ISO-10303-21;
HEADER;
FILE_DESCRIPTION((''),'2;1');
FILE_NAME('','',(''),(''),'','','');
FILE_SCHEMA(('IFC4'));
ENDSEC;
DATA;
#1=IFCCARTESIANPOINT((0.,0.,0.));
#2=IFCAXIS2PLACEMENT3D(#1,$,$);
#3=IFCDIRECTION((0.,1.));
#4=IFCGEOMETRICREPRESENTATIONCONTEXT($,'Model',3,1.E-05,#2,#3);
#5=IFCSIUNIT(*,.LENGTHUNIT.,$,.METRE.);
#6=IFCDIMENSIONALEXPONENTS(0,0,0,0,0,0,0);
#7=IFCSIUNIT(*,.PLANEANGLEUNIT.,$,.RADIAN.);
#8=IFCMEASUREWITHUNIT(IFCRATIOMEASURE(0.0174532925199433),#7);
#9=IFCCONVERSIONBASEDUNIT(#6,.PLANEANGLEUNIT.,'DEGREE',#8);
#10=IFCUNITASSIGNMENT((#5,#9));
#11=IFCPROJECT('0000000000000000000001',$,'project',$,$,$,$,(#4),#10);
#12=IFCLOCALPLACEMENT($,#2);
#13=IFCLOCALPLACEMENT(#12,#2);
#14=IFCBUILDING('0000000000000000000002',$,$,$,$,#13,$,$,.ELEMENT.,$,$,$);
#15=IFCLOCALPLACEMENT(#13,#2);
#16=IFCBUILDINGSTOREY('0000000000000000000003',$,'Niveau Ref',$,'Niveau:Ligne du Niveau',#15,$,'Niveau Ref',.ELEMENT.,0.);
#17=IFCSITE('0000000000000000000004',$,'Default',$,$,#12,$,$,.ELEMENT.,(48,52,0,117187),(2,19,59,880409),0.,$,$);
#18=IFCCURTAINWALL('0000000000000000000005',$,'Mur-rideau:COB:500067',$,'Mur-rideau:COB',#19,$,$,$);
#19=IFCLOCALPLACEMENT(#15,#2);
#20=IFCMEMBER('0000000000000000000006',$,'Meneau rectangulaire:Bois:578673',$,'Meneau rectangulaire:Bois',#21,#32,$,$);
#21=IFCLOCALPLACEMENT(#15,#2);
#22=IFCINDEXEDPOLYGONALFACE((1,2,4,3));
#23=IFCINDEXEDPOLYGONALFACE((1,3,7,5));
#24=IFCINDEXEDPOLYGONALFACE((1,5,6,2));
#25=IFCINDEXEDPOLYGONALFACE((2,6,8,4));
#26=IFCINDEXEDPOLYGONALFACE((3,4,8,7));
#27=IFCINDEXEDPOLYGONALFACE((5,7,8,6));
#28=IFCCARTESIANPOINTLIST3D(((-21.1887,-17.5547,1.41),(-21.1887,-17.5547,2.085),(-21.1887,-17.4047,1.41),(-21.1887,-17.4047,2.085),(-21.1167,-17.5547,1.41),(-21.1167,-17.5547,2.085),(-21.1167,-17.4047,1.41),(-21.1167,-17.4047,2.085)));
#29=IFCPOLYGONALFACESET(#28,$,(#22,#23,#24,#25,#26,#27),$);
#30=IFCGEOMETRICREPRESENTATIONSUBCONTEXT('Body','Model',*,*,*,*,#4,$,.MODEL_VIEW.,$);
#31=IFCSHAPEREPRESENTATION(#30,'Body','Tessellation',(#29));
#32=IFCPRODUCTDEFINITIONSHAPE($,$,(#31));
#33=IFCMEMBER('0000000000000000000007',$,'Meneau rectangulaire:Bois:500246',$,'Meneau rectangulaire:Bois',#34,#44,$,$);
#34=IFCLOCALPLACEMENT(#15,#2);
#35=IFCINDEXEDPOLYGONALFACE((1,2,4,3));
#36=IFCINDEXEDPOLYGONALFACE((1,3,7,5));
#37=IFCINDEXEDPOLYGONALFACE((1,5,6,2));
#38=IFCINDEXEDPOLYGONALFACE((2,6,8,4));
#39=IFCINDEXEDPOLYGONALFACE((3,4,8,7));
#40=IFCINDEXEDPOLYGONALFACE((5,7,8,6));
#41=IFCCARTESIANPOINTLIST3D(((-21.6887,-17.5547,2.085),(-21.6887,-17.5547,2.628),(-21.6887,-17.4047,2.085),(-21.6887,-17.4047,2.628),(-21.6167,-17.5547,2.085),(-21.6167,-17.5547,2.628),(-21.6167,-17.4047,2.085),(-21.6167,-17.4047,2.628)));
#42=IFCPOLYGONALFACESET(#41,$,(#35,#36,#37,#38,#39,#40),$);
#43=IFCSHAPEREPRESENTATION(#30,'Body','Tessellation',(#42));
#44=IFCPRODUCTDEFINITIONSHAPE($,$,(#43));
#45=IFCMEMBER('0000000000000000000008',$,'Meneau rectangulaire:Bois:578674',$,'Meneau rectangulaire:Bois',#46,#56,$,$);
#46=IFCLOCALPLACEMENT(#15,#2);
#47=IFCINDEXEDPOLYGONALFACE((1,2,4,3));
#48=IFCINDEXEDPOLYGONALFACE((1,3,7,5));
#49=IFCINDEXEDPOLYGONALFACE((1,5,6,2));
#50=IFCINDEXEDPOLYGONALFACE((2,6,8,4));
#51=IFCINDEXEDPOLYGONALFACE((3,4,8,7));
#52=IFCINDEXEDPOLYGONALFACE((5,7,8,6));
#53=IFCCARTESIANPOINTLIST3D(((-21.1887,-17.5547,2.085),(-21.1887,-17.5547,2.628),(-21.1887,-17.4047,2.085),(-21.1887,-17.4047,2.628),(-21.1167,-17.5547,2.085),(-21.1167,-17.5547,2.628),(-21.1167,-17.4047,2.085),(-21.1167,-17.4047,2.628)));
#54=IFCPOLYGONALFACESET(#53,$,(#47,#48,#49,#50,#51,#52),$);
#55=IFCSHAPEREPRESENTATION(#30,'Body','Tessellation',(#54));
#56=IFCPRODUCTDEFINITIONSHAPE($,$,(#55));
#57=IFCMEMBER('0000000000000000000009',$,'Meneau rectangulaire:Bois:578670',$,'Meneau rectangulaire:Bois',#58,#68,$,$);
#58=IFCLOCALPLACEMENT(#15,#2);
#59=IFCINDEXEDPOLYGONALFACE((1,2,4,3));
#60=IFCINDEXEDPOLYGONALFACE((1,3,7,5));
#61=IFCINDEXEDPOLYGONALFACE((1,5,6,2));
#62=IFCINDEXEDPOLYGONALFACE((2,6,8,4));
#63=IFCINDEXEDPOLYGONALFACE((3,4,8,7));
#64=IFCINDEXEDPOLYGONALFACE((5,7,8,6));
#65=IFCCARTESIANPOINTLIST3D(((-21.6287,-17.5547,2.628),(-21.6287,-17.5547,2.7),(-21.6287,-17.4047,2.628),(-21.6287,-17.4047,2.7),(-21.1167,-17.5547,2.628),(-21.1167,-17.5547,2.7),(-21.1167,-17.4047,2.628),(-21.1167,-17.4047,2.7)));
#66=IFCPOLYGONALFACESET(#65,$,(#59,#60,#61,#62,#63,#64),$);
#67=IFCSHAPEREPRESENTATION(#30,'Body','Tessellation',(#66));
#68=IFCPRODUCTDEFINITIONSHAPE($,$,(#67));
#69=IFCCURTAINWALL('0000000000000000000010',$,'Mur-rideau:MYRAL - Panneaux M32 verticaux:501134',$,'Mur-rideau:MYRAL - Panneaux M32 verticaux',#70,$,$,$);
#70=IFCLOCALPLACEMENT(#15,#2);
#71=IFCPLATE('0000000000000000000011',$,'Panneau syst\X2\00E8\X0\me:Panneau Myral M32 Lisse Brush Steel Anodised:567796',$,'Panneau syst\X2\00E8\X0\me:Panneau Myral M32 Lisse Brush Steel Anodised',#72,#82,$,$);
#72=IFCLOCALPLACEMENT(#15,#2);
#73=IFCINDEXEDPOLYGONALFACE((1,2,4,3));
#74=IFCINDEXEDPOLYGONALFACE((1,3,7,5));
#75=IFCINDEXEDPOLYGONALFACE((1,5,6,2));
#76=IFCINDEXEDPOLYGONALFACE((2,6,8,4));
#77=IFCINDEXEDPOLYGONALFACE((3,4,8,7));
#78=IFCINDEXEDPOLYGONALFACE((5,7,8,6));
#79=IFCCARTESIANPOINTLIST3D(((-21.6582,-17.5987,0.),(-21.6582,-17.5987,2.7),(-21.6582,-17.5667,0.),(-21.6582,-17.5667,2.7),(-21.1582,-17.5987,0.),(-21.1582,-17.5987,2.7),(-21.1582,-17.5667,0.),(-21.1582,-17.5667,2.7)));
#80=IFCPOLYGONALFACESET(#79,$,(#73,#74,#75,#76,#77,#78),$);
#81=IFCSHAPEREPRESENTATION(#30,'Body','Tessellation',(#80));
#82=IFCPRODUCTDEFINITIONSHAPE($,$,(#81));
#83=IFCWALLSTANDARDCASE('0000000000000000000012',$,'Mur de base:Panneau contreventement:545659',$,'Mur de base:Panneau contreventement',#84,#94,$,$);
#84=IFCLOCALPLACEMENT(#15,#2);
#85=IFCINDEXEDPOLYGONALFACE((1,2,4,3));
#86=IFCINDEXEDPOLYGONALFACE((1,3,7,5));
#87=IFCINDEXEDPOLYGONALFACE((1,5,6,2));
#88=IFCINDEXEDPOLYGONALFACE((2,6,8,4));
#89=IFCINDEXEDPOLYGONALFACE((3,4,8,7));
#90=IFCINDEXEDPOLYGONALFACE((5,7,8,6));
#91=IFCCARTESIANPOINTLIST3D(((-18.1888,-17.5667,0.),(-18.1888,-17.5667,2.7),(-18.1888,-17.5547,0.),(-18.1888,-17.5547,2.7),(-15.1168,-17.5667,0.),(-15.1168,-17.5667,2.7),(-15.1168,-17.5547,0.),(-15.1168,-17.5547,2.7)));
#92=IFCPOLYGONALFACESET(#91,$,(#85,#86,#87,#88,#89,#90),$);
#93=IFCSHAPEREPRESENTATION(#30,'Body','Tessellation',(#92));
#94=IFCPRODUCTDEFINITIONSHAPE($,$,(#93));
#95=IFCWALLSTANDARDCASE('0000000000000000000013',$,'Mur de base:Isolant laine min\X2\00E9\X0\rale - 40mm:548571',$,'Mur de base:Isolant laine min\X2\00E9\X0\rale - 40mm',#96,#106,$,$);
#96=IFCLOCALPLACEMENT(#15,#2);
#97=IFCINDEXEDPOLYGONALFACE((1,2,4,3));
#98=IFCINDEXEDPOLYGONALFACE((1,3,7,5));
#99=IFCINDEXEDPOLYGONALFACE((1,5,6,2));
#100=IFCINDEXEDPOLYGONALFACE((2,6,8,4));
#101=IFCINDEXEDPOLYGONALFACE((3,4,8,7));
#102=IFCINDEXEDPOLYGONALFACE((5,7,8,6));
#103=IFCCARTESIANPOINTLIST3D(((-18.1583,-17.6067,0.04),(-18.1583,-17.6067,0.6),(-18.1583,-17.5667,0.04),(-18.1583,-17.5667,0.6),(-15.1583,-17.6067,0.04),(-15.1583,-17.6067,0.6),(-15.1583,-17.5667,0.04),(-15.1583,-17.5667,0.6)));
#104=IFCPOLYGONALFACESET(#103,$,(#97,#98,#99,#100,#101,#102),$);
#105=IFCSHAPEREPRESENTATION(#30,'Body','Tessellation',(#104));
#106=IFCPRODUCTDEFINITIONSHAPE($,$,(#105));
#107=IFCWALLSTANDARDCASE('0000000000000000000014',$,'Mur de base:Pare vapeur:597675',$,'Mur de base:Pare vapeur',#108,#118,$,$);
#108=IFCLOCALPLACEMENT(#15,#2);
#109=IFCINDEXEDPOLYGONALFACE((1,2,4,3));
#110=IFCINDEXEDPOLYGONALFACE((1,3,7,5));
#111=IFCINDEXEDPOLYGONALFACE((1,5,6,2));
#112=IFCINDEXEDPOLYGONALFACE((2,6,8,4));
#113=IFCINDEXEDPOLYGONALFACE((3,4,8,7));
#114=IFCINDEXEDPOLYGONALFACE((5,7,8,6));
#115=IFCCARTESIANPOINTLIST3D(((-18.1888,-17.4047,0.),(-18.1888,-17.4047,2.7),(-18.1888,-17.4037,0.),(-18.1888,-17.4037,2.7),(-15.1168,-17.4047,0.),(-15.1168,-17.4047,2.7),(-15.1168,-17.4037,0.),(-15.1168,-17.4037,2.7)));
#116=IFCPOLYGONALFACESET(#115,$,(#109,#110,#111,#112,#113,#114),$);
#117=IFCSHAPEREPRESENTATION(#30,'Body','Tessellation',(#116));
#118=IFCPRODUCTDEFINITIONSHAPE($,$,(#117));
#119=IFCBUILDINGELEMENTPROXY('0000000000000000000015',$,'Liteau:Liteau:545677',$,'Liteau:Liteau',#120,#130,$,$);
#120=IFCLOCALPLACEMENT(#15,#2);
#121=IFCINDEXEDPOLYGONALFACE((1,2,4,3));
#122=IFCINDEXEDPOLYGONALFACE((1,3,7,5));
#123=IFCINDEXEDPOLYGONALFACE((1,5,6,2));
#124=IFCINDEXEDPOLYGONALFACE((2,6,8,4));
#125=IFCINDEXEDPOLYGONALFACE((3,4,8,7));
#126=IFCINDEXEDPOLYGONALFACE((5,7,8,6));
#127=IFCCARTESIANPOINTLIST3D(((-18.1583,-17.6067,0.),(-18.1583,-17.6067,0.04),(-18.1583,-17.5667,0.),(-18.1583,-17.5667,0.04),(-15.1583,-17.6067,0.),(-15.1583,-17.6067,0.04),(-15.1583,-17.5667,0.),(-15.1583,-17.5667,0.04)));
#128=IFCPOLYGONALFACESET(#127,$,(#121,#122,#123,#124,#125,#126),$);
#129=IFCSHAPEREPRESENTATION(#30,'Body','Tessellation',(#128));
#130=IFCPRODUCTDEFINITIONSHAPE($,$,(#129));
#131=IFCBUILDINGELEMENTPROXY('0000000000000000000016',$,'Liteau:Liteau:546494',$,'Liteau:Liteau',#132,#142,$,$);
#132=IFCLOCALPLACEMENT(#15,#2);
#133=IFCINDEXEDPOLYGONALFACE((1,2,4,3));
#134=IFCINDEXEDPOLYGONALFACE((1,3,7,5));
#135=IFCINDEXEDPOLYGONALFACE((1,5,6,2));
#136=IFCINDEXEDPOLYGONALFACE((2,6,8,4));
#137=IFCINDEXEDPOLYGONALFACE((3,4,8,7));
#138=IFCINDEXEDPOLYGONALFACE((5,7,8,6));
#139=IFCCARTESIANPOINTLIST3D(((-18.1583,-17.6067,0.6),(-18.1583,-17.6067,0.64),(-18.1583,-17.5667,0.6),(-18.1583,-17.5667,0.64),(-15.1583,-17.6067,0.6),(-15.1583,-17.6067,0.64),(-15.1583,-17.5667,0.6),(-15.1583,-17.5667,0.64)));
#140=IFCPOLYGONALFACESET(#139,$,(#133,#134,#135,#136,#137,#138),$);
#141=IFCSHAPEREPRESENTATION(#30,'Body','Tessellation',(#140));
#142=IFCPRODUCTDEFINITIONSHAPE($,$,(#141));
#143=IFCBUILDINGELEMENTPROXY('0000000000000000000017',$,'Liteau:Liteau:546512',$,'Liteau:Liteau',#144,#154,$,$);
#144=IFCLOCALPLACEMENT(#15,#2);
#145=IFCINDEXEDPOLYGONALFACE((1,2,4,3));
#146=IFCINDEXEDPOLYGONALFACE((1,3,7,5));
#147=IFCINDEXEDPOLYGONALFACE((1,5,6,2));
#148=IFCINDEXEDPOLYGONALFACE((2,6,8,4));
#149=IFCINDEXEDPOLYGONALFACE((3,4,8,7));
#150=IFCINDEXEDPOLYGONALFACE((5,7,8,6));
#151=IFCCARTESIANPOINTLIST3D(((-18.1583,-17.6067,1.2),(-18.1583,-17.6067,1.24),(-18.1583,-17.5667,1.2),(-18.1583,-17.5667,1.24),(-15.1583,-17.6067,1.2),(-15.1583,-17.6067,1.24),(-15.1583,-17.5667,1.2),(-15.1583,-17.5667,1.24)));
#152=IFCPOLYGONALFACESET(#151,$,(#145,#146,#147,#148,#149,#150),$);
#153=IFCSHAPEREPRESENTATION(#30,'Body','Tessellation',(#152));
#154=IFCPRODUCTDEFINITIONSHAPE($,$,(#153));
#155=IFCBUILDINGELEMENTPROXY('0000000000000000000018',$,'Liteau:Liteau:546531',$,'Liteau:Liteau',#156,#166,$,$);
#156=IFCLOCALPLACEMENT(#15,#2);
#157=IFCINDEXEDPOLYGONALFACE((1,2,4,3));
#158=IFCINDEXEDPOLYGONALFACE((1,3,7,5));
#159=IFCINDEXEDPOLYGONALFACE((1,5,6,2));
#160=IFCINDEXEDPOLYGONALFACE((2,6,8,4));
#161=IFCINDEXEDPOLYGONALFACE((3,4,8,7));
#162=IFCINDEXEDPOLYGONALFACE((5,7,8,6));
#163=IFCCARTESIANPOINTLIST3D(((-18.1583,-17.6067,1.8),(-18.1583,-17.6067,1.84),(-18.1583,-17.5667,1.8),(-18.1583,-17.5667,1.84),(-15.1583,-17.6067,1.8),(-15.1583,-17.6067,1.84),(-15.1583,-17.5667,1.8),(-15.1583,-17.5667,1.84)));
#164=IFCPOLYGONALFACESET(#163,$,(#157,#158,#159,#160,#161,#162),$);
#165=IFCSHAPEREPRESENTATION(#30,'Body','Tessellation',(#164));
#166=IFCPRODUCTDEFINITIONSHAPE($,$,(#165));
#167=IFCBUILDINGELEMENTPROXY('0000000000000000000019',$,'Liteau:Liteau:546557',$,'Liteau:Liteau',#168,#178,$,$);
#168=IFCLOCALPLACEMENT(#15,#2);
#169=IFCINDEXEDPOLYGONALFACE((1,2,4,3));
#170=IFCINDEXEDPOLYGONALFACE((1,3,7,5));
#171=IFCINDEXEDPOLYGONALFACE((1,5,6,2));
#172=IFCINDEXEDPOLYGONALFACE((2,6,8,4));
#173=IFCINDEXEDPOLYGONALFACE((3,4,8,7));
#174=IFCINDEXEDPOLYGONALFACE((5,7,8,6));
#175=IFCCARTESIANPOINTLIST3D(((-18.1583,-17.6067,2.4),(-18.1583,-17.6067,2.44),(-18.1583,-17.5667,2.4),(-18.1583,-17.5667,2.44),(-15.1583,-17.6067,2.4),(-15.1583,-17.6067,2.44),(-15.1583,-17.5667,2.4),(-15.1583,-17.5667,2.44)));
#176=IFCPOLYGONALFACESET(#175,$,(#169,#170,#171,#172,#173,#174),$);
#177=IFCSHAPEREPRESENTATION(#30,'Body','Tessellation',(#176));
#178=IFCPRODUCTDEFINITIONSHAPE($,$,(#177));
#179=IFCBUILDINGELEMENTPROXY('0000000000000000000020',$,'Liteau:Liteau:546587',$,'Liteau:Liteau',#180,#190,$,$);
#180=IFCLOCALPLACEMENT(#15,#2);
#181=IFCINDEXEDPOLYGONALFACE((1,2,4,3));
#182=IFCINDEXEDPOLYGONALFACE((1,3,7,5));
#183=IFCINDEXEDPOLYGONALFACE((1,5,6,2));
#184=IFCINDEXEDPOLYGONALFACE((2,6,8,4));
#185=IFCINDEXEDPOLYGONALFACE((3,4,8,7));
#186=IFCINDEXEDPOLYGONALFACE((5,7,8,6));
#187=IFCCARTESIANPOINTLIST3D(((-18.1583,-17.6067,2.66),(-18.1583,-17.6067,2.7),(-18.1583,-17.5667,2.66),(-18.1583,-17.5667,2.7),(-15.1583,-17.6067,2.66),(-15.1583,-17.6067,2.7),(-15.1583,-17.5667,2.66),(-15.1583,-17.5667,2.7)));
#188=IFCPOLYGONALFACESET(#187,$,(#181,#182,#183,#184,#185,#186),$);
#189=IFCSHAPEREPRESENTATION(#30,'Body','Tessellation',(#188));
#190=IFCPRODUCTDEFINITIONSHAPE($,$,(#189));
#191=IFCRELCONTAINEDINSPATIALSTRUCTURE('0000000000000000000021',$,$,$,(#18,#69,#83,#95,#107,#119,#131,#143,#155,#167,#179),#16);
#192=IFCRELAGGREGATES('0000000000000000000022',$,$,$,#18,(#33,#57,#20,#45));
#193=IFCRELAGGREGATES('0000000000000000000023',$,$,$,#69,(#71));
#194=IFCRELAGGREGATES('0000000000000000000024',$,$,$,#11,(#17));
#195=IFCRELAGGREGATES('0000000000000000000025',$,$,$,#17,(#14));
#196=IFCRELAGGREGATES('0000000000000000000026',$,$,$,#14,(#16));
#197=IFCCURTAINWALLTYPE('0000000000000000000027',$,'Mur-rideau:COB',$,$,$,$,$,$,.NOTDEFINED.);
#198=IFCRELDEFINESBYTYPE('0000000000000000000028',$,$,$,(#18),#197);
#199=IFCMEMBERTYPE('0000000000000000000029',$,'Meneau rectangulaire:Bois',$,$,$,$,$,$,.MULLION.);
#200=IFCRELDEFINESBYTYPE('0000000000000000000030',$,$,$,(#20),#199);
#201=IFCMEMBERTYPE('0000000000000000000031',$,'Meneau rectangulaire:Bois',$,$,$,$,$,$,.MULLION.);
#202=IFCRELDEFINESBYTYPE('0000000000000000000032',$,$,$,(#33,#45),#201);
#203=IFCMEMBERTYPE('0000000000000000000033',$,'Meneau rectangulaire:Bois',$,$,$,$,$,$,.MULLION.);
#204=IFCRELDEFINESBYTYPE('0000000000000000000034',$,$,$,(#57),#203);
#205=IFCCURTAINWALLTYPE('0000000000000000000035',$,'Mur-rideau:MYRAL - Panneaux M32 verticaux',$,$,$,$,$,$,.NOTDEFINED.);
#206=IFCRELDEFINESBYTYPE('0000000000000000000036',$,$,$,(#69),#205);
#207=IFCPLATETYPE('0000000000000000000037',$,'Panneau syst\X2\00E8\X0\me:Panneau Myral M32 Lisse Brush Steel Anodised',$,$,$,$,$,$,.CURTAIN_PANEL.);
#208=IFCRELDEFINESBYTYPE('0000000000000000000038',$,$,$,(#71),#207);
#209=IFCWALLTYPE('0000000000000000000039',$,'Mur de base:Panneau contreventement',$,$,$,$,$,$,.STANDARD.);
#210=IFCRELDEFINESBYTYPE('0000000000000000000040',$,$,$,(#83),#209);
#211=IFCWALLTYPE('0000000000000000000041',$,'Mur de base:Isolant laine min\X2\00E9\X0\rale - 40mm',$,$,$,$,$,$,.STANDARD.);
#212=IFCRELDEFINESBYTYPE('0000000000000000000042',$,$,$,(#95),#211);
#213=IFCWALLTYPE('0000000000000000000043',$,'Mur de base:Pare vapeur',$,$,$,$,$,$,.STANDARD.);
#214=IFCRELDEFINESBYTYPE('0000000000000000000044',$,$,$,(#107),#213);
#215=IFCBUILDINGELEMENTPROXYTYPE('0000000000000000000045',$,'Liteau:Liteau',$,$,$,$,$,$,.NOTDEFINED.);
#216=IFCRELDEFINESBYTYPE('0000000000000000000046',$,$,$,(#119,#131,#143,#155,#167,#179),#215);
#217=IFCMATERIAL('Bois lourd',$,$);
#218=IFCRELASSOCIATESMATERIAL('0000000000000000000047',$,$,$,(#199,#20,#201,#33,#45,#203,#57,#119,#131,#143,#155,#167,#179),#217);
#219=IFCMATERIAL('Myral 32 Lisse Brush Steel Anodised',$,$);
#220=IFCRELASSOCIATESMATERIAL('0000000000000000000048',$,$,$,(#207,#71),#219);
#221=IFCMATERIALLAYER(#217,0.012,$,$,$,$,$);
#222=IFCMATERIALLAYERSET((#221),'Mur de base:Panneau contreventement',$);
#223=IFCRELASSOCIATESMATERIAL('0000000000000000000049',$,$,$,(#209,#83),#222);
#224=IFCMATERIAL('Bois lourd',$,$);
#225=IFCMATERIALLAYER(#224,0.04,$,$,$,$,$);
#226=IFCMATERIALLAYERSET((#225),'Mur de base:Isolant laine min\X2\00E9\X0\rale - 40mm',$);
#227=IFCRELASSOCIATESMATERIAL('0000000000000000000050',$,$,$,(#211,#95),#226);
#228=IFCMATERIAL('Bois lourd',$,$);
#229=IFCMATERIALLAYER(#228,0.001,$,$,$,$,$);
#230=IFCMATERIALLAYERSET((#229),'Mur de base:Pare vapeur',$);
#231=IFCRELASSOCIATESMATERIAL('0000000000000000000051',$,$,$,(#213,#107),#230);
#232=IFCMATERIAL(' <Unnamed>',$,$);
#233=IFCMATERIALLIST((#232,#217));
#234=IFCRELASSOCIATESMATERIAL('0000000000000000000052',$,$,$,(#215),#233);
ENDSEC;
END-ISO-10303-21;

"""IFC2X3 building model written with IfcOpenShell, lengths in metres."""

from ifc_helpers import new_model, entity, si_unit, converted_unit, direction, frame, frame_2d, origin, origin_2d_with_axis, place, context, subcontext, project, spatial, rectangle, extrude, source, transform, mapped, material, material_list, layer, layer_set, layer_usage, type_object, type_shapes, element, aggregate, save


model = new_model("IFC2X3")

# Units and contexts
model_context = context("Model", 3, precision=1e-05, world=origin(), true_north=direction((0.0, 1.0)))
body_context = subcontext(model_context, "Body", "Model", "MODEL_VIEW")
ifc_project = project(units=[si_unit("LENGTHUNIT", "METRE"), converted_unit("PLANEANGLEUNIT", "DEGREE", entity("IfcRatioMeasure", 0.0174532925199433), si_unit("PLANEANGLEUNIT", "RADIAN"), dimensions=[0, 0, 0, 0, 0, 0, 0])], contexts=[model_context])

# Site, building, storey
site_placement = place(None, origin())
site = spatial("IfcSite", under=ifc_project, at=site_placement, Name="Default", CompositionType="ELEMENT", RefLatitude=(48, 52, 0, 117187), RefLongitude=(2, 19, 59, 880409), RefElevation=0.0)
building_placement = place(site_placement, origin())
building = spatial("IfcBuilding", under=site, at=building_placement, CompositionType="ELEMENT")
storey_placement = place(building_placement, origin())
storey = spatial("IfcBuildingStorey", under=building, at=storey_placement, Name="Niveau Ref", ObjectType="Niveau:Ligne du Niveau", LongName="Niveau Ref", CompositionType="ELEMENT", Elevation=0.0)

# Curtain wall, members
curtain_wall_type_1 = type_object("IfcCurtainWallType", Name="Mur-rideau:COB", PredefinedType="NOTDEFINED")
ifc_material_1 = material(Name="Bois lourd")
curtain_wall_1_placement = place(storey_placement, origin())
curtain_wall_1 = element("IfcCurtainWall", 1, at=curtain_wall_1_placement, inside=storey, type_object=curtain_wall_type_1, Name="Mur-rideau:COB:500067", ObjectType="Mur-rideau:COB")
member_type_1 = type_object("IfcMemberType", Name="Meneau rectangulaire:Bois", PredefinedType="MULLION", material=ifc_material_1)
shared_shape_1 = source(origin(), body_context, "Body", "SweptSolid", [
    extrude(rectangle(XDim=0.15, YDim=0.072, at=origin_2d_with_axis()), frame((-0.024, 0.0, -0.675), z_axis=(0.0, 0.0, 1.0), x_axis=(0.0, -1.0, 0.0)), (0.0, 0.0, 1.0), 0.675),
])
type_shapes(member_type_1, [shared_shape_1])
member_1_placement = place(storey_placement, frame((-21.1287, -17.4797, 1.41), z_axis=(0.0, 0.0, -1.0), x_axis=(1.0, 0.0, 0.0)))
member_1 = element("IfcMember", 2, at=member_1_placement, type_object=member_type_1, material=ifc_material_1, Name="Meneau rectangulaire:Bois:578673", ObjectType="Meneau rectangulaire:Bois", context=body_context, shape_type="MappedRepresentation", body=[
    mapped(shared_shape_1, transform((0.0, 0.0, 0.0), scale=1.0)),
])
member_type_2 = type_object("IfcMemberType", Name="Meneau rectangulaire:Bois", PredefinedType="MULLION", material=ifc_material_1)
shared_shape_2 = source(origin(), body_context, "Body", "SweptSolid", [
    extrude(rectangle(XDim=0.15, YDim=0.072, at=origin_2d_with_axis()), frame((-0.024, 0.0, -0.543), z_axis=(0.0, 0.0, 1.0), x_axis=(0.0, -1.0, 0.0)), (0.0, 0.0, 1.0), 0.543),
])
type_shapes(member_type_2, [shared_shape_2])
member_2_placement = place(storey_placement, frame((-21.6287, -17.4797, 2.085), z_axis=(0.0, 0.0, -1.0), x_axis=(1.0, 0.0, 0.0)))
member_2 = element("IfcMember", 3, at=member_2_placement, type_object=member_type_2, material=ifc_material_1, Name="Meneau rectangulaire:Bois:500246", ObjectType="Meneau rectangulaire:Bois", context=body_context, shape_type="MappedRepresentation", body=[
    mapped(shared_shape_2, transform((0.0, 0.0, 0.0), scale=1.0)),
])
member_3_placement = place(storey_placement, frame((-21.1287, -17.4797, 2.085), z_axis=(0.0, 0.0, -1.0), x_axis=(1.0, 0.0, 0.0)))
member_3 = element("IfcMember", 4, at=member_3_placement, type_object=member_type_2, material=ifc_material_1, Name="Meneau rectangulaire:Bois:578674", ObjectType="Meneau rectangulaire:Bois", context=body_context, shape_type="MappedRepresentation", body=[
    mapped(shared_shape_2, transform((0.0, 0.0, 0.0), scale=1.0)),
])
member_type_3 = type_object("IfcMemberType", Name="Meneau rectangulaire:Bois", PredefinedType="MULLION", material=ifc_material_1)
shared_shape_3 = source(origin(), body_context, "Body", "SweptSolid", [
    extrude(rectangle(XDim=0.15, YDim=0.072, at=origin_2d_with_axis()), frame((-0.036, 0.0, -0.512), z_axis=(0.0, 0.0, 1.0), x_axis=(0.0, -1.0, 0.0)), (0.0, 0.0, 1.0), 0.512),
])
type_shapes(member_type_3, [shared_shape_3])
member_4_placement = place(storey_placement, frame((-21.1167, -17.4797, 2.7), z_axis=(1.0, 0.0, 0.0), x_axis=(0.0, 0.0, 1.0)))
member_4 = element("IfcMember", 5, at=member_4_placement, type_object=member_type_3, material=ifc_material_1, Name="Meneau rectangulaire:Bois:578670", ObjectType="Meneau rectangulaire:Bois", context=body_context, shape_type="MappedRepresentation", body=[
    mapped(shared_shape_3, transform((0.0, 0.0, 0.0), scale=1.0)),
])
aggregate(curtain_wall_1, [member_2, member_4, member_1, member_3])

# Curtain wall, plate
curtain_wall_type_2 = type_object("IfcCurtainWallType", Name="Mur-rideau:MYRAL - Panneaux M32 verticaux", PredefinedType="NOTDEFINED")
curtain_wall_2_placement = place(storey_placement, origin())
curtain_wall_2 = element("IfcCurtainWall", 6, at=curtain_wall_2_placement, inside=storey, type_object=curtain_wall_type_2, Name="Mur-rideau:MYRAL - Panneaux M32 verticaux:501134", ObjectType="Mur-rideau:MYRAL - Panneaux M32 verticaux")
ifc_material_2 = material(Name="Myral 32 Lisse Brush Steel Anodised")
plate_type = type_object("IfcPlateType", Name="Panneau système:Panneau Myral M32 Lisse Brush Steel Anodised", PredefinedType="CURTAIN_PANEL", material=ifc_material_2)
shared_shape_4 = source(origin(), body_context, "Body", "SweptSolid", [
    extrude(rectangle(XDim=0.032, YDim=0.5, at=origin_2d_with_axis()), frame((0.0, -0.016, 0.0), z_axis=(0.0, 0.0, 1.0), x_axis=(0.0, 1.0, 0.0)), (0.0, 0.0, 1.0), 2.7),
])
type_shapes(plate_type, [shared_shape_4])
plate_placement = place(curtain_wall_2_placement, frame((-21.4082, -17.5667, 0.0)))
plate = element("IfcPlate", 7, at=plate_placement, type_object=plate_type, material=ifc_material_2, Name="Panneau système:Panneau Myral M32 Lisse Brush Steel Anodised:567796", ObjectType="Panneau système:Panneau Myral M32 Lisse Brush Steel Anodised", context=body_context, shape_type="MappedRepresentation", body=[
    mapped(shared_shape_4, transform((0.0, 0.0, 0.0), scale=1.0)),
])
aggregate(curtain_wall_2, [plate])

# Walls
ifc_layer_1 = layer(ifc_material_1, 0.012)
ifc_layer_set_1 = layer_set([ifc_layer_1], Name="Mur de base:Panneau contreventement")
ifc_layer_usage_1 = layer_usage(ifc_layer_set_1, "AXIS2", "NEGATIVE", 0.006)
wall_type_1 = type_object("IfcWallType", Name="Mur de base:Panneau contreventement", PredefinedType="STANDARD", material=ifc_layer_set_1)
wall_1_placement = place(storey_placement, frame((-18.1888, -17.5607, 0.0)))
element("IfcWallStandardCase", 8, at=wall_1_placement, inside=storey, type_object=wall_type_1, material=ifc_layer_usage_1, Name="Mur de base:Panneau contreventement:545659", ObjectType="Mur de base:Panneau contreventement", context=body_context, shape_type="SweptSolid", body=[
    extrude(rectangle(XDim=3.072, YDim=0.012, at=frame_2d((1.536, 0.0), x_axis=(-1.0, 0.0))), origin(), (0.0, 0.0, 1.0), 2.7),
])
ifc_material_3 = material(Name="Bois lourd")
ifc_layer_2 = layer(ifc_material_3, 0.04)
ifc_layer_set_2 = layer_set([ifc_layer_2], Name="Mur de base:Isolant laine minérale - 40mm")
ifc_layer_usage_2 = layer_usage(ifc_layer_set_2, "AXIS2", "NEGATIVE", 0.02)
wall_type_2 = type_object("IfcWallType", Name="Mur de base:Isolant laine minérale - 40mm", PredefinedType="STANDARD", material=ifc_layer_set_2)
wall_2_placement = place(storey_placement, frame((-18.1583, -17.5867, 0.04)))
element("IfcWallStandardCase", 9, at=wall_2_placement, inside=storey, type_object=wall_type_2, material=ifc_layer_usage_2, Name="Mur de base:Isolant laine minérale - 40mm:548571", ObjectType="Mur de base:Isolant laine minérale - 40mm", context=body_context, shape_type="SweptSolid", body=[
    extrude(rectangle(XDim=3.0, YDim=0.04, at=frame_2d((1.5, 0.0), x_axis=(-1.0, 0.0))), origin(), (0.0, 0.0, 1.0), 0.56),
])
ifc_material_4 = material(Name="Bois lourd")
ifc_layer_3 = layer(ifc_material_4, 0.001)
ifc_layer_set_3 = layer_set([ifc_layer_3], Name="Mur de base:Pare vapeur")
ifc_layer_usage_3 = layer_usage(ifc_layer_set_3, "AXIS2", "NEGATIVE", 0.0005)
wall_type_3 = type_object("IfcWallType", Name="Mur de base:Pare vapeur", PredefinedType="STANDARD", material=ifc_layer_set_3)
wall_3_placement = place(storey_placement, frame((-18.1888, -17.4042, 0.0)))
element("IfcWallStandardCase", 10, at=wall_3_placement, inside=storey, type_object=wall_type_3, material=ifc_layer_usage_3, Name="Mur de base:Pare vapeur:597675", ObjectType="Mur de base:Pare vapeur", context=body_context, shape_type="SweptSolid", body=[
    extrude(rectangle(XDim=3.072, YDim=0.001, at=frame_2d((1.536, 0.0), x_axis=(-1.0, 0.0))), origin(), (0.0, 0.0, 1.0), 2.7),
])

# Building element proxies
ifc_material_5 = material(Name=" <Unnamed>")
ifc_material_list = material_list([ifc_material_5, ifc_material_1])
building_element_proxy_type = type_object("IfcBuildingElementProxyType", Name="Liteau:Liteau", PredefinedType="NOTDEFINED", material=ifc_material_list)
shared_shape_5 = source(origin(), body_context, "Body", "SweptSolid", [
    extrude(rectangle(XDim=3.0, YDim=0.04, at=origin_2d_with_axis()), frame((1.5, -0.02, 0.0), z_axis=(0.0, 0.0, 1.0), x_axis=(-1.0, 0.0, 0.0)), (0.0, 0.0, 1.0), 0.04),
])
type_shapes(building_element_proxy_type, [shared_shape_5])
for number, where, name in (
    (11, (-18.1583, -17.5667, 0.0), "Liteau:Liteau:545677"),
    (12, (-18.1583, -17.5667, 0.6), "Liteau:Liteau:546494"),
    (13, (-18.1583, -17.5667, 1.2), "Liteau:Liteau:546512"),
    (14, (-18.1583, -17.5667, 1.8), "Liteau:Liteau:546531"),
    (15, (-18.1583, -17.5667, 2.4), "Liteau:Liteau:546557"),
    (16, (-18.1583, -17.5667, 2.66), "Liteau:Liteau:546587"),
):
    element("IfcBuildingElementProxy", number, at=place(storey_placement, frame(where)), inside=storey, type_object=building_element_proxy_type, material=ifc_material_1, Name=name, ObjectType="Liteau:Liteau", context=body_context, shape_type="MappedRepresentation", body=[
        mapped(shared_shape_5, transform((0.0, 0.0, 0.0), scale=1.0)),
    ])

save(model, "model.ifc")
